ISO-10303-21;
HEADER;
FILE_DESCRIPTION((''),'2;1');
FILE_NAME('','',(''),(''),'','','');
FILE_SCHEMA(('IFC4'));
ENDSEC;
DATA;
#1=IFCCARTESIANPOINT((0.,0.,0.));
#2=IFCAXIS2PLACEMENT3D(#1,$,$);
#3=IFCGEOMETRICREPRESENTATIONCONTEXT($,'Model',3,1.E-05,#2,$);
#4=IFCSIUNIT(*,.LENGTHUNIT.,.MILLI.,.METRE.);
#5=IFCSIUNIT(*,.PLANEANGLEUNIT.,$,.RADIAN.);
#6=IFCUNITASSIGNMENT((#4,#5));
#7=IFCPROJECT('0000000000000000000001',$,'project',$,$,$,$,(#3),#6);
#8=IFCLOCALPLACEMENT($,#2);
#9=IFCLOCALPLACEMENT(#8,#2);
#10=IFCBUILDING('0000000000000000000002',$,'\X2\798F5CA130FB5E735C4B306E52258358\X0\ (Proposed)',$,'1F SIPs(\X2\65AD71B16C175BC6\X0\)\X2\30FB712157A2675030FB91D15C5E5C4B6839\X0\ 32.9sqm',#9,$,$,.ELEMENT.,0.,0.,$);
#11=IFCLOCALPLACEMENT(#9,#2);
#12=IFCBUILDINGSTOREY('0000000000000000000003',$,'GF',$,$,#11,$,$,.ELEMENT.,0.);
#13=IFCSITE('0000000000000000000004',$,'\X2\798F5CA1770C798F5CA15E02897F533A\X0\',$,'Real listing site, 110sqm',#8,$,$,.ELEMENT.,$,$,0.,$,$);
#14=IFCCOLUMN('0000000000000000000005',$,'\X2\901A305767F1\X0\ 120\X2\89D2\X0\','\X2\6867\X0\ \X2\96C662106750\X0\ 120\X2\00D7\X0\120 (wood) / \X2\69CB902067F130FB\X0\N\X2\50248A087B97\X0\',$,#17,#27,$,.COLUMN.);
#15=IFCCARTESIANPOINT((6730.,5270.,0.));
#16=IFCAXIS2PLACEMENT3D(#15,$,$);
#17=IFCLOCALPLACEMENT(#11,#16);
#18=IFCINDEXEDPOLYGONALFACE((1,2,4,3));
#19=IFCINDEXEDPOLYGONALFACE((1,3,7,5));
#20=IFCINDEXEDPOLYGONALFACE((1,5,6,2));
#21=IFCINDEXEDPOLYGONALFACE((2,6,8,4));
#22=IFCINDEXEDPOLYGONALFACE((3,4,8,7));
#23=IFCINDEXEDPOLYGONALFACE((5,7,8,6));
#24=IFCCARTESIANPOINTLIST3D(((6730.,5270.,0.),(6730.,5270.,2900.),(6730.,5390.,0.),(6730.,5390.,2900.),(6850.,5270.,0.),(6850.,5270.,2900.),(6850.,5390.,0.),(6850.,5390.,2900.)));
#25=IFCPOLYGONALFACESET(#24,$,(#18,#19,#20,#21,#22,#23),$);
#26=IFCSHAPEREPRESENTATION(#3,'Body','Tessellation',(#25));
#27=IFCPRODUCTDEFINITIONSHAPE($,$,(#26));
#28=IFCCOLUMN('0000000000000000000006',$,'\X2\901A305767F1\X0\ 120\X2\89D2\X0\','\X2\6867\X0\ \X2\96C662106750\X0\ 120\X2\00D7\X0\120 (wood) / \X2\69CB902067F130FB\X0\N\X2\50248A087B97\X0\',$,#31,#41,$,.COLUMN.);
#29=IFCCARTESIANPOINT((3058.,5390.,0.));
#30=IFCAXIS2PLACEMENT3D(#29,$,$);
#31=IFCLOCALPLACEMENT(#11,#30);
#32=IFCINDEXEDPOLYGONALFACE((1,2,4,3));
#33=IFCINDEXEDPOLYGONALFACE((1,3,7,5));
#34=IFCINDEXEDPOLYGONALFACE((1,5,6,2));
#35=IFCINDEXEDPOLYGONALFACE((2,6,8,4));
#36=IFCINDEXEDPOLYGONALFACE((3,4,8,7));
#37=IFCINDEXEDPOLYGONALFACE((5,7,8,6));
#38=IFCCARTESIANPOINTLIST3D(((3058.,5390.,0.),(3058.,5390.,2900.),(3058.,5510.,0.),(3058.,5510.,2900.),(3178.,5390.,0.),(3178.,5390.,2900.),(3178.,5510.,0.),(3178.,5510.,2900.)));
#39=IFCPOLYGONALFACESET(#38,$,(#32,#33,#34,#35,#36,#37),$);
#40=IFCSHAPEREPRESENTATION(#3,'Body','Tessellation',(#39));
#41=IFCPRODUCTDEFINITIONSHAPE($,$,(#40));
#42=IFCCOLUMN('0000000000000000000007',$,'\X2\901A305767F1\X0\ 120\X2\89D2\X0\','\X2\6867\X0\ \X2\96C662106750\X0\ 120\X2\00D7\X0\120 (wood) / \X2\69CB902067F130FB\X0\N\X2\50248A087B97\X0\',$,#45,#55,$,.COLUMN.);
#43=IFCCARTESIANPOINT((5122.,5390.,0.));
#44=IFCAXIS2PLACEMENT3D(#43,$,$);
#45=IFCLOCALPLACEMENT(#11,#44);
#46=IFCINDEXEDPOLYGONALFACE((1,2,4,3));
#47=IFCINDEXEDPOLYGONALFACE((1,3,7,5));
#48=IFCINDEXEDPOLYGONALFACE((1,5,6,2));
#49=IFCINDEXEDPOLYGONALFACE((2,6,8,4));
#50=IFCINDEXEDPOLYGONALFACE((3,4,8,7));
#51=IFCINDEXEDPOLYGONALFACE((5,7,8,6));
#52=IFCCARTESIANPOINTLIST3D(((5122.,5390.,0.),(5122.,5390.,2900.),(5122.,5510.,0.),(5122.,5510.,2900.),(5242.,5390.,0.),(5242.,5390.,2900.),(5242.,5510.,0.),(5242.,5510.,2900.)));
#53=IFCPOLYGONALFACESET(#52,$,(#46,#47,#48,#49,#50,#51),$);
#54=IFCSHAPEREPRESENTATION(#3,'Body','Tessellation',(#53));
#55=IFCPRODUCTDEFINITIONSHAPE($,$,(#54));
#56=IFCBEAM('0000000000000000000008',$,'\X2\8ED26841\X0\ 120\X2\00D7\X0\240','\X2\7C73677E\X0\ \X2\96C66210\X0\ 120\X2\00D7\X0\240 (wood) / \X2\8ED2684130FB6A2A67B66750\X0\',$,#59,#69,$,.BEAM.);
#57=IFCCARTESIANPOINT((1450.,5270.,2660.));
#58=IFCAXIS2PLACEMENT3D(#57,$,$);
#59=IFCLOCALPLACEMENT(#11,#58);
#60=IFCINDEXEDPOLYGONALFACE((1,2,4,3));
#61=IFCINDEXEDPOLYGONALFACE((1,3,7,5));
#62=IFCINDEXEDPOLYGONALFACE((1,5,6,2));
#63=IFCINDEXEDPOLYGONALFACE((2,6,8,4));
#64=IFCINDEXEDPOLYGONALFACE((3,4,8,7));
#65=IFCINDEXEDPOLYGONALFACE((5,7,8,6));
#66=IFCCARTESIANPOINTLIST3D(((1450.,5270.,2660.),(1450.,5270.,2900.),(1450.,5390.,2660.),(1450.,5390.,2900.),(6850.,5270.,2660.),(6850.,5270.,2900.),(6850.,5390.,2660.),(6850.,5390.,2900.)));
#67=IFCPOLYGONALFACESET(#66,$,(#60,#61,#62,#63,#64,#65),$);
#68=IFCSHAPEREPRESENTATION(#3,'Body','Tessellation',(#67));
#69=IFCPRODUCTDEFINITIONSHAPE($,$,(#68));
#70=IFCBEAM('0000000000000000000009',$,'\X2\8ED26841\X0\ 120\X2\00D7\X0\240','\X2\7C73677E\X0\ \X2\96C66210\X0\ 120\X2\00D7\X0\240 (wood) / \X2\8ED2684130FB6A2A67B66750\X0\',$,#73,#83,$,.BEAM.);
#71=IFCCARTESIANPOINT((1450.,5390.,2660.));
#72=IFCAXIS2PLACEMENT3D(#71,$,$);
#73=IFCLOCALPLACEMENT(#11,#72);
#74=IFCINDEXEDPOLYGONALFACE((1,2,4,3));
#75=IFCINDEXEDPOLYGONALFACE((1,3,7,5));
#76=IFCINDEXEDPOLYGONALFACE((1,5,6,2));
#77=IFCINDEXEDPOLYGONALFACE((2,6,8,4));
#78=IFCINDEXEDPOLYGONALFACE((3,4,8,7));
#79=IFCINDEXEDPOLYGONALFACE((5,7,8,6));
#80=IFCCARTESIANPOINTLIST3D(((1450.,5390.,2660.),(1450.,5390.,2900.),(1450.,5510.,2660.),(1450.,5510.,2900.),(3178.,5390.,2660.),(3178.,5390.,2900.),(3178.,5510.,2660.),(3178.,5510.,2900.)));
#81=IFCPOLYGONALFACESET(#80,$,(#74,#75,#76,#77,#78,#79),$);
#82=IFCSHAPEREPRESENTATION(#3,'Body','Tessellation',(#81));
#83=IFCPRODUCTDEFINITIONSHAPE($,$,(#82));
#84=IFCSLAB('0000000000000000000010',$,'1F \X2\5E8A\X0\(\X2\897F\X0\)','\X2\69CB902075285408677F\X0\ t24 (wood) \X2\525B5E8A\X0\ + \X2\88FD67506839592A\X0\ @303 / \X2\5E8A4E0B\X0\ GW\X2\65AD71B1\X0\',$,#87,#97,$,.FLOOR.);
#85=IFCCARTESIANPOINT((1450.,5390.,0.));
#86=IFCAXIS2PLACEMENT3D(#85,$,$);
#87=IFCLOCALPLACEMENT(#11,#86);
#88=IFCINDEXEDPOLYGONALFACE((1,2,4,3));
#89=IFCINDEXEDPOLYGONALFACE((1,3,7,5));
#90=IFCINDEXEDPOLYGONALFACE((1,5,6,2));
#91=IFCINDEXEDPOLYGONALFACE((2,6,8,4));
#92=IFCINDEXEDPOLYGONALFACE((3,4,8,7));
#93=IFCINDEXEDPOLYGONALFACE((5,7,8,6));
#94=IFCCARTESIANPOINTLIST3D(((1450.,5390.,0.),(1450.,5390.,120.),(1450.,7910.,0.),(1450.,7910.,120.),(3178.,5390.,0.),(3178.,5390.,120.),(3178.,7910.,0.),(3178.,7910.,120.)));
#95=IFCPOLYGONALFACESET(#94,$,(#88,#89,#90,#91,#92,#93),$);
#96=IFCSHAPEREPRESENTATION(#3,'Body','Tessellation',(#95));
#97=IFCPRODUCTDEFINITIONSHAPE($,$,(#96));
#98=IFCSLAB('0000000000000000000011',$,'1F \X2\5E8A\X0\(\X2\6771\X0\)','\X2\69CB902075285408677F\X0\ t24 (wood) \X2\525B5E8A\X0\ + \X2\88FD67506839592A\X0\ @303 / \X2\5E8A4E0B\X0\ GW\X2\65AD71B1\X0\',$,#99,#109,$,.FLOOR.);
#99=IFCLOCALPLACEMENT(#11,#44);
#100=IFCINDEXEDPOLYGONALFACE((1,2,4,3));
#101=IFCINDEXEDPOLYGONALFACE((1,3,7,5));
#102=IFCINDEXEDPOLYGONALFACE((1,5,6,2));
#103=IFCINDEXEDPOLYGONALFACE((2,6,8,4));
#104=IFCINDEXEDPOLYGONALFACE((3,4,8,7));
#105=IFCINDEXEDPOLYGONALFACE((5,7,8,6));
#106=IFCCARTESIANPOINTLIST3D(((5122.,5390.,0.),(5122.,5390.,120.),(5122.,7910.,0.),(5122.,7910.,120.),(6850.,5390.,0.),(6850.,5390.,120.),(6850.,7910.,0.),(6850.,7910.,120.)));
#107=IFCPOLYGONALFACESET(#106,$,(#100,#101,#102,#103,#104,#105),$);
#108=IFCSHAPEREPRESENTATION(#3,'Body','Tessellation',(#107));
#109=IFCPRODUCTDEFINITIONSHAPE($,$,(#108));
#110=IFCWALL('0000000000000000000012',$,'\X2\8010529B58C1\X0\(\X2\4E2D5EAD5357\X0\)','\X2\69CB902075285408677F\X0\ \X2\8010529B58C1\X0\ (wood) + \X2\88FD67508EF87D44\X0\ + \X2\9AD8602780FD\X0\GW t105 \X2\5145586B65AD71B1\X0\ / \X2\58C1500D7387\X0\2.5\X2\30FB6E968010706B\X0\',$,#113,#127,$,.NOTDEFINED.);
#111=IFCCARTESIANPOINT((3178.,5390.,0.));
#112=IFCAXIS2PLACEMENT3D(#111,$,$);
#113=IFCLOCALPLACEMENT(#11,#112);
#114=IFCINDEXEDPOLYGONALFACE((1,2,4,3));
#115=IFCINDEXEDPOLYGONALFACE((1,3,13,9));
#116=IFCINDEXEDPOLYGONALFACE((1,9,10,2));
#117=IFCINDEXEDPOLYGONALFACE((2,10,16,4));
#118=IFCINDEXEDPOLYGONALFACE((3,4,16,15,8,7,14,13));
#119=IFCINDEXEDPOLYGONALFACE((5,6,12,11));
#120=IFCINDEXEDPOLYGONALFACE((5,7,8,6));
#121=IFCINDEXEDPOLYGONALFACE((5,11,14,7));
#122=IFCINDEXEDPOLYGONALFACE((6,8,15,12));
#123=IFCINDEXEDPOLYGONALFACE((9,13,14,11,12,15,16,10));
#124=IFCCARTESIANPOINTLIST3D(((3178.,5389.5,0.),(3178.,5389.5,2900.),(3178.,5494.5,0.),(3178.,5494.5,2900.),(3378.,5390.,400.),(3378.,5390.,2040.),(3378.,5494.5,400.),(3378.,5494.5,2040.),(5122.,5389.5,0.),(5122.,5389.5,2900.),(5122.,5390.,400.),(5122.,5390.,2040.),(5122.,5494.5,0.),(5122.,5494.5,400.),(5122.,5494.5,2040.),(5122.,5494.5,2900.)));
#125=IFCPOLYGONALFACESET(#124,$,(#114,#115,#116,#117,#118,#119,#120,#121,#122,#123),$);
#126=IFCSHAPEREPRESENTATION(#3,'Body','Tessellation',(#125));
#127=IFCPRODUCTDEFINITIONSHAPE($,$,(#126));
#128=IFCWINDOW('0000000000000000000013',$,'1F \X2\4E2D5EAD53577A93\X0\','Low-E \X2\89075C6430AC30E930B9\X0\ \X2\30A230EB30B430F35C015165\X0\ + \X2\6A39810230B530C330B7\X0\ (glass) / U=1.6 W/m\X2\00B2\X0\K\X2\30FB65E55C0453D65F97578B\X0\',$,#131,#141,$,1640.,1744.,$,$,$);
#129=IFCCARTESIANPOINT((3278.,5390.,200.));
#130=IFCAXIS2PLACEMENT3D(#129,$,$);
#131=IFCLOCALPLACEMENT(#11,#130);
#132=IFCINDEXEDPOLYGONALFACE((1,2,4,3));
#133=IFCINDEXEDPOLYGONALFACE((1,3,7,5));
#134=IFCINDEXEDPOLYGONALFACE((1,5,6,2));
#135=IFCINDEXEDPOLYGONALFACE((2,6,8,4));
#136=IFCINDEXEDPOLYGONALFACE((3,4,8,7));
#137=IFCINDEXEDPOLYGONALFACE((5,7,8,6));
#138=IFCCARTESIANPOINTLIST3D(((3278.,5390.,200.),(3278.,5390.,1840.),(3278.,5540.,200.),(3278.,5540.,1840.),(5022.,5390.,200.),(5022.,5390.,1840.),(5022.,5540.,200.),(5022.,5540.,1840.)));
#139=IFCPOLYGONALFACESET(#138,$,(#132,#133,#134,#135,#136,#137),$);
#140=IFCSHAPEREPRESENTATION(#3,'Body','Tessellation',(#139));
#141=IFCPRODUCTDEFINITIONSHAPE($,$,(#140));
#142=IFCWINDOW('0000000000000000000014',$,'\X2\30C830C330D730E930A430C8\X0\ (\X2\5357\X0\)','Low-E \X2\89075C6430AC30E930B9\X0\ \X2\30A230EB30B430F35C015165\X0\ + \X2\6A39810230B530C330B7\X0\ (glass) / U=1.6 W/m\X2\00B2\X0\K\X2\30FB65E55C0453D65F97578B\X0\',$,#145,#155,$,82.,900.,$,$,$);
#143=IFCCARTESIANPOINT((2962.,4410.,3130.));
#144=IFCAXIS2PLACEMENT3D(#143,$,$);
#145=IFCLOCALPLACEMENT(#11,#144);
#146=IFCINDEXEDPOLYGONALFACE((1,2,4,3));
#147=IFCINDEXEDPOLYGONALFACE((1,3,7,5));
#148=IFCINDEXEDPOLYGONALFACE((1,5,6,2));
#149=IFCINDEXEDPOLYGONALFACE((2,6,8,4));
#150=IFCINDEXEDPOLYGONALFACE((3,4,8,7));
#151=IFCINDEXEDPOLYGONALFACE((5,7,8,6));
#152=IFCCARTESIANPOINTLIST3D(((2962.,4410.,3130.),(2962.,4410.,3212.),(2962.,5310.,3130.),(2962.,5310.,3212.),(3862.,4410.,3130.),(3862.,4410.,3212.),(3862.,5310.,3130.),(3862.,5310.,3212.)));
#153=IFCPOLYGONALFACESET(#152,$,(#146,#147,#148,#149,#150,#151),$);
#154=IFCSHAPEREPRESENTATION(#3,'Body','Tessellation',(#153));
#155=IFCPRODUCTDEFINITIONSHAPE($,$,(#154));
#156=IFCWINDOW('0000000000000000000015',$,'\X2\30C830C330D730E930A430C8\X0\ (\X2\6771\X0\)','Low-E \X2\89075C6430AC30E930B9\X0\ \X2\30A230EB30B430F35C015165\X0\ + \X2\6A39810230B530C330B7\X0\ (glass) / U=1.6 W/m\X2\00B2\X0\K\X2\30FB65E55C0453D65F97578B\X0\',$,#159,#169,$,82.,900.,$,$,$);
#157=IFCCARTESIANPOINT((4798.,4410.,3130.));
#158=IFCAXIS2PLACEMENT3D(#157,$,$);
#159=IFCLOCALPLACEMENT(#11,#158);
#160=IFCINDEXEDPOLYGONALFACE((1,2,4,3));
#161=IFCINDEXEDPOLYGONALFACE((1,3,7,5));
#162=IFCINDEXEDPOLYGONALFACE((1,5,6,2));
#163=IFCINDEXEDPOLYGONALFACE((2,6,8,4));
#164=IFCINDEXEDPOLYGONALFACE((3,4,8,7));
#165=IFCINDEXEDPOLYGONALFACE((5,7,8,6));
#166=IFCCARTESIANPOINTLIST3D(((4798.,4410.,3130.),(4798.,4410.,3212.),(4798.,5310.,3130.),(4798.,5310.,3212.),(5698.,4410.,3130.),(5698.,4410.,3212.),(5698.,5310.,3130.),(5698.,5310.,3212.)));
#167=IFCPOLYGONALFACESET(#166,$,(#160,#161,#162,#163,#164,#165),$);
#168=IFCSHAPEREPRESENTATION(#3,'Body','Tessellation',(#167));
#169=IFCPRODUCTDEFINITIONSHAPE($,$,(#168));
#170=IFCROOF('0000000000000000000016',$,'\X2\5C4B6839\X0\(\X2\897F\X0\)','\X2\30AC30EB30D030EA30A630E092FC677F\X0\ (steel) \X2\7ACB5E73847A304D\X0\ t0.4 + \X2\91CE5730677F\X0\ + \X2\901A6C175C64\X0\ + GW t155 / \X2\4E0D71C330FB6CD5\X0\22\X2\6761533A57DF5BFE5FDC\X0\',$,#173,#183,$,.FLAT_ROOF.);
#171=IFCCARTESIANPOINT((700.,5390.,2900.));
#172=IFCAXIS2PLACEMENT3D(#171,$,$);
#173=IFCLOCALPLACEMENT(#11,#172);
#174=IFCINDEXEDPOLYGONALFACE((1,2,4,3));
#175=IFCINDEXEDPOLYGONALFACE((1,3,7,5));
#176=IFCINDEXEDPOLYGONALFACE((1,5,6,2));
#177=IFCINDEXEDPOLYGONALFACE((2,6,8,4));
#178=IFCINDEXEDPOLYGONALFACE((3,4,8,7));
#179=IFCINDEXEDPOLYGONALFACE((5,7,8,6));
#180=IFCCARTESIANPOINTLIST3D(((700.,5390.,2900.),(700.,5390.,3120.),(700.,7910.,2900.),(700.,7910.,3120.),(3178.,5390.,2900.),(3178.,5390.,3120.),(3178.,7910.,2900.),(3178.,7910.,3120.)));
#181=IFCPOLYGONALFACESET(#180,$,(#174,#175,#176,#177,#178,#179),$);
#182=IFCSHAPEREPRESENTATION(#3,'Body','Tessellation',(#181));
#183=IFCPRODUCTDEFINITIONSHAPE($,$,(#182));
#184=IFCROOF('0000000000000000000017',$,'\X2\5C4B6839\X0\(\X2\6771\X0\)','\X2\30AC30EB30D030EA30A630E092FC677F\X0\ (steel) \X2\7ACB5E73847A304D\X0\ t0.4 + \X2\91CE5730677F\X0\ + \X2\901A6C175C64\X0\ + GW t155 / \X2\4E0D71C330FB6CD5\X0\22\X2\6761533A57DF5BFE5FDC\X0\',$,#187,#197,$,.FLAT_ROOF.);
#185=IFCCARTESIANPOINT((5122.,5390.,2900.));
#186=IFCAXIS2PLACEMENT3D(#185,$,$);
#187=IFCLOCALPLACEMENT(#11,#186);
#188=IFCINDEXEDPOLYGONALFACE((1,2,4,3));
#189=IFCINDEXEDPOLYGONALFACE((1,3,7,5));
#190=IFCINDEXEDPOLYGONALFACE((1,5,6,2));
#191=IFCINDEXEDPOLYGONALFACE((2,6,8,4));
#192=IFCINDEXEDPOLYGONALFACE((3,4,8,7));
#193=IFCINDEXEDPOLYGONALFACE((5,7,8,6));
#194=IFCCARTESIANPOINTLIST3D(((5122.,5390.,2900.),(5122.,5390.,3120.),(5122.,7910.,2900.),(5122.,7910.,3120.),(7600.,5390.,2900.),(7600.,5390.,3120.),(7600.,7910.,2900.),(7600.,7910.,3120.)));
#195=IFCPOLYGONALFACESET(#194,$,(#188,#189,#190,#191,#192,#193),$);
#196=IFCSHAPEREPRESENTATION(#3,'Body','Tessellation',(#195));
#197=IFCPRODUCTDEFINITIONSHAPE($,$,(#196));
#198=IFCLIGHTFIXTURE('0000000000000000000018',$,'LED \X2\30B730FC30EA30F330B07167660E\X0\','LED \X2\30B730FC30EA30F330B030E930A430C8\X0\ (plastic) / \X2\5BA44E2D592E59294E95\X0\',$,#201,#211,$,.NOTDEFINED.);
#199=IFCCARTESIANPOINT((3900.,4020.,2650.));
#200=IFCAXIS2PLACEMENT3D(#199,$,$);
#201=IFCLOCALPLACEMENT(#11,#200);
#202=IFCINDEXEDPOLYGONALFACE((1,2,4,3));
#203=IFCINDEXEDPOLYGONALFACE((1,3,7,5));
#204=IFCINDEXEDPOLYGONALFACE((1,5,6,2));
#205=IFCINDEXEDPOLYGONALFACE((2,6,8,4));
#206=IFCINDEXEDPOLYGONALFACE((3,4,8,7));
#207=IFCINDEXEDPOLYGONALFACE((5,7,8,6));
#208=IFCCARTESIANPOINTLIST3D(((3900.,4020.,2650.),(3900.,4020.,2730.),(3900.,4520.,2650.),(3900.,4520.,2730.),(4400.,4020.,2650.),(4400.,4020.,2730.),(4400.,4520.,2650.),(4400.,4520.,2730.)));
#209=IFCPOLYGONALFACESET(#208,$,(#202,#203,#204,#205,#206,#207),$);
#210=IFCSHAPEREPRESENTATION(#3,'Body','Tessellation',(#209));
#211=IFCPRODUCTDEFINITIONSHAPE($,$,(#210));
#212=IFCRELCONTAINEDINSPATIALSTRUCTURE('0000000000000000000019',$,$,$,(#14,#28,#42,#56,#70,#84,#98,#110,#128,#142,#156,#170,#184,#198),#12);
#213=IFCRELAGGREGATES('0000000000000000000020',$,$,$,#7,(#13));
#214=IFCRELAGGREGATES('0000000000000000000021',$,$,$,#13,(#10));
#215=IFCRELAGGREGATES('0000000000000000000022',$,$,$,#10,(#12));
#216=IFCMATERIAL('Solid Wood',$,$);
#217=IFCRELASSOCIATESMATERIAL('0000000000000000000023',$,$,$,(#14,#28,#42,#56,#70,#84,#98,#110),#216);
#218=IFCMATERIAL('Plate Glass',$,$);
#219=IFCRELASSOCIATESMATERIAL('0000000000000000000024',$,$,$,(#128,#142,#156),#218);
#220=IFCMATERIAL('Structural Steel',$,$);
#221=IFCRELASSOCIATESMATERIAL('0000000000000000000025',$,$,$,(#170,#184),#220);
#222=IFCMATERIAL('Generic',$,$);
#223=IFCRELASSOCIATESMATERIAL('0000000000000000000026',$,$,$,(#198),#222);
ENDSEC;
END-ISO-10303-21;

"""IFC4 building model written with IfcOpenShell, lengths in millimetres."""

from ifc_helpers import new_model, si_unit, frame, frame_2d, origin, place, context, project, spatial, rectangle, extrude, material, element, fill, save


model = new_model("IFC4")

# Units and contexts
model_context = context("Model", 3, precision=1e-05, world=origin())
ifc_project = project(units=[si_unit("LENGTHUNIT", "METRE", prefix="MILLI"), si_unit("PLANEANGLEUNIT", "RADIAN")], contexts=[model_context])

# Site, building, storey
site_placement = place(None, origin())
site = spatial("IfcSite", under=ifc_project, at=site_placement, Name="福岡県福岡市西区", ObjectType="Real listing site, 110sqm", CompositionType="ELEMENT", RefElevation=0.0)
building_placement = place(site_placement, origin())
building = spatial("IfcBuilding", under=site, at=building_placement, Name="福岡・平屋の別荘 (Proposed)", ObjectType="1F SIPs(断熱気密)・無垢材・金属屋根 32.9sqm", CompositionType="ELEMENT", ElevationOfRefHeight=0.0, ElevationOfTerrain=0.0)
storey_placement = place(building_placement, origin())
storey = spatial("IfcBuildingStorey", under=building, at=storey_placement, Name="GF", CompositionType="ELEMENT", Elevation=0.0)

# Columns
ifc_material_1 = material(Name="Solid Wood")
column_1_placement = place(storey_placement, frame((6730.0, 5270.0, 0.0)))
element("IfcColumn", 1, at=column_1_placement, inside=storey, material=ifc_material_1, Name="通し柱 120角", Description="桧 集成材 120×120 (wood) / 構造柱・N値計算", PredefinedType="COLUMN", context=model_context, shape_type="SweptSolid", body=[
    extrude(rectangle(XDim=120.0, YDim=120.0, at=frame_2d((60.0, 60.0))), frame((6730.0, 5270.0, 0.0)), (0.0, 0.0, 1.0), 2900.0),
])
column_2_placement = place(storey_placement, frame((3058.0, 5390.0, 0.0)))
element("IfcColumn", 2, at=column_2_placement, inside=storey, material=ifc_material_1, Name="通し柱 120角", Description="桧 集成材 120×120 (wood) / 構造柱・N値計算", PredefinedType="COLUMN", context=model_context, shape_type="SweptSolid", body=[
    extrude(rectangle(XDim=120.0, YDim=120.0, at=frame_2d((60.0, 60.0))), frame((3058.0, 5390.0, 0.0)), (0.0, 0.0, 1.0), 2900.0),
])
column_3_placement = place(storey_placement, frame((5122.0, 5390.0, 0.0)))
element("IfcColumn", 3, at=column_3_placement, inside=storey, material=ifc_material_1, Name="通し柱 120角", Description="桧 集成材 120×120 (wood) / 構造柱・N値計算", PredefinedType="COLUMN", context=model_context, shape_type="SweptSolid", body=[
    extrude(rectangle(XDim=120.0, YDim=120.0, at=frame_2d((60.0, 60.0))), frame((5122.0, 5390.0, 0.0)), (0.0, 0.0, 1.0), 2900.0),
])

# Beams
beam_1_placement = place(storey_placement, frame((1450.0, 5270.0, 2660.0)))
element("IfcBeam", 4, at=beam_1_placement, inside=storey, material=ifc_material_1, Name="軒桁 120×240", Description="米松 集成 120×240 (wood) / 軒桁・横架材", PredefinedType="BEAM", context=model_context, shape_type="SweptSolid", body=[
    extrude(rectangle(XDim=5400.0, YDim=120.0, at=frame_2d((2700.0, 60.0))), frame((1450.0, 5270.0, 2660.0)), (0.0, 0.0, 1.0), 240.0),
])
beam_2_placement = place(storey_placement, frame((1450.0, 5390.0, 2660.0)))
element("IfcBeam", 5, at=beam_2_placement, inside=storey, material=ifc_material_1, Name="軒桁 120×240", Description="米松 集成 120×240 (wood) / 軒桁・横架材", PredefinedType="BEAM", context=model_context, shape_type="SweptSolid", body=[
    extrude(rectangle(XDim=1728.0, YDim=120.0, at=frame_2d((864.0, 60.0))), frame((1450.0, 5390.0, 2660.0)), (0.0, 0.0, 1.0), 240.0),
])

# Slabs
slab_1_placement = place(storey_placement, frame((1450.0, 5390.0, 0.0)))
element("IfcSlab", 6, at=slab_1_placement, inside=storey, material=ifc_material_1, Name="1F 床(西)", Description="構造用合板 t24 (wood) 剛床 + 製材根太 @303 / 床下 GW断熱", PredefinedType="FLOOR", context=model_context, shape_type="SweptSolid", body=[
    extrude(rectangle(XDim=1728.0, YDim=2520.0, at=frame_2d((864.0, 1260.0))), frame((1450.0, 5390.0, 0.0)), (0.0, 0.0, 1.0), 120.0),
])
slab_2_placement = place(storey_placement, frame((5122.0, 5390.0, 0.0)))
element("IfcSlab", 7, at=slab_2_placement, inside=storey, material=ifc_material_1, Name="1F 床(東)", Description="構造用合板 t24 (wood) 剛床 + 製材根太 @303 / 床下 GW断熱", PredefinedType="FLOOR", context=model_context, shape_type="SweptSolid", body=[
    extrude(rectangle(XDim=1728.0, YDim=2520.0, at=frame_2d((864.0, 1260.0))), frame((5122.0, 5390.0, 0.0)), (0.0, 0.0, 1.0), 120.0),
])

# Wall, opening, window
wall_1_placement = place(storey_placement, frame((3178.0, 5390.0, 0.0)))
wall_1 = element("IfcWall", 8, at=wall_1_placement, inside=storey, material=ifc_material_1, Name="耐力壁(中庭南)", Description="構造用合板 耐力壁 (wood) + 製材軸組 + 高性能GW t105 充填断熱 / 壁倍率2.5・準耐火", PredefinedType="NOTDEFINED", context=model_context, shape_type="SweptSolid", body=[
    extrude(rectangle(XDim=1944.0, YDim=105.0, at=frame_2d((972.0, 52.0))), frame((3178.0, 5390.0, 0.0)), (0.0, 0.0, 1.0), 2900.0),
])
opening_placement = place(storey_placement, frame((3278.0, 5390.0, 200.0)))
opening = element("IfcOpeningElement", 9, at=opening_placement, cuts=wall_1, PredefinedType="NOTDEFINED", context=model_context, shape_type="SweptSolid", body=[
    extrude(rectangle(XDim=1744.0, YDim=150.0, at=frame_2d((872.0, 75.0))), frame((3278.0, 5390.0, 200.0)), (0.0, 0.0, 1.0), 1640.0),
])
ifc_material_2 = material(Name="Plate Glass")
window_1_placement = place(storey_placement, frame((3278.0, 5390.0, 200.0)))
window_1 = element("IfcWindow", 10, at=window_1_placement, inside=storey, material=ifc_material_2, Name="1F 中庭南窓", Description="Low-E 複層ガラス アルゴン封入 + 樹脂サッシ (glass) / U=1.6 W/m²K・日射取得型", OverallHeight=1640.0, OverallWidth=1744.0, context=model_context, shape_type="SweptSolid", body=[
    extrude(rectangle(XDim=1744.0, YDim=150.0, at=frame_2d((872.0, 75.0))), frame((3278.0, 5390.0, 200.0)), (0.0, 0.0, 1.0), 1640.0),
])
fill(opening, window_1)

# Windows
window_2_placement = place(storey_placement, frame((2962.0, 4410.0, 3130.0)))
element("IfcWindow", 11, at=window_2_placement, inside=storey, material=ifc_material_2, Name="トップライト (南)", Description="Low-E 複層ガラス アルゴン封入 + 樹脂サッシ (glass) / U=1.6 W/m²K・日射取得型", OverallHeight=82.0, OverallWidth=900.0, context=model_context, shape_type="SweptSolid", body=[
    extrude(rectangle(XDim=900.0, YDim=900.0, at=frame_2d((450.0, 450.0))), frame((2962.0, 4410.0, 3130.0)), (0.0, 0.0, 1.0), 82.0),
])
window_3_placement = place(storey_placement, frame((4798.0, 4410.0, 3130.0)))
element("IfcWindow", 12, at=window_3_placement, inside=storey, material=ifc_material_2, Name="トップライト (東)", Description="Low-E 複層ガラス アルゴン封入 + 樹脂サッシ (glass) / U=1.6 W/m²K・日射取得型", OverallHeight=82.0, OverallWidth=900.0, context=model_context, shape_type="SweptSolid", body=[
    extrude(rectangle(XDim=900.0, YDim=900.0, at=frame_2d((450.0, 450.0))), frame((4798.0, 4410.0, 3130.0)), (0.0, 0.0, 1.0), 82.0),
])

# Roofs
ifc_material_3 = material(Name="Structural Steel")
roof_1_placement = place(storey_placement, frame((700.0, 5390.0, 2900.0)))
element("IfcRoof", 13, at=roof_1_placement, inside=storey, material=ifc_material_3, Name="屋根(西)", Description="ガルバリウム鋼板 (steel) 立平葺き t0.4 + 野地板 + 通気層 + GW t155 / 不燃・法22条区域対応", PredefinedType="FLAT_ROOF", context=model_context, shape_type="SweptSolid", body=[
    extrude(rectangle(XDim=2478.0, YDim=2520.0, at=frame_2d((1239.0, 1260.0))), frame((700.0, 5390.0, 2900.0)), (0.0, 0.0, 1.0), 220.0),
])
roof_2_placement = place(storey_placement, frame((5122.0, 5390.0, 2900.0)))
element("IfcRoof", 14, at=roof_2_placement, inside=storey, material=ifc_material_3, Name="屋根(東)", Description="ガルバリウム鋼板 (steel) 立平葺き t0.4 + 野地板 + 通気層 + GW t155 / 不燃・法22条区域対応", PredefinedType="FLAT_ROOF", context=model_context, shape_type="SweptSolid", body=[
    extrude(rectangle(XDim=2478.0, YDim=2520.0, at=frame_2d((1239.0, 1260.0))), frame((5122.0, 5390.0, 2900.0)), (0.0, 0.0, 1.0), 220.0),
])

# Light fixture
ifc_material_4 = material(Name="Generic")
light_fixture_placement = place(storey_placement, frame((3900.0, 4020.0, 2650.0)))
element("IfcLightFixture", 15, at=light_fixture_placement, inside=storey, material=ifc_material_4, Name="LED シーリング照明", Description="LED シーリングライト (plastic) / 室中央天井", PredefinedType="NOTDEFINED", context=model_context, shape_type="SweptSolid", body=[
    extrude(rectangle(XDim=500.0, YDim=500.0, at=frame_2d((250.0, 250.0))), frame((3900.0, 4020.0, 2650.0)), (0.0, 0.0, 1.0), 80.0),
])

save(model, "model.ifc")
